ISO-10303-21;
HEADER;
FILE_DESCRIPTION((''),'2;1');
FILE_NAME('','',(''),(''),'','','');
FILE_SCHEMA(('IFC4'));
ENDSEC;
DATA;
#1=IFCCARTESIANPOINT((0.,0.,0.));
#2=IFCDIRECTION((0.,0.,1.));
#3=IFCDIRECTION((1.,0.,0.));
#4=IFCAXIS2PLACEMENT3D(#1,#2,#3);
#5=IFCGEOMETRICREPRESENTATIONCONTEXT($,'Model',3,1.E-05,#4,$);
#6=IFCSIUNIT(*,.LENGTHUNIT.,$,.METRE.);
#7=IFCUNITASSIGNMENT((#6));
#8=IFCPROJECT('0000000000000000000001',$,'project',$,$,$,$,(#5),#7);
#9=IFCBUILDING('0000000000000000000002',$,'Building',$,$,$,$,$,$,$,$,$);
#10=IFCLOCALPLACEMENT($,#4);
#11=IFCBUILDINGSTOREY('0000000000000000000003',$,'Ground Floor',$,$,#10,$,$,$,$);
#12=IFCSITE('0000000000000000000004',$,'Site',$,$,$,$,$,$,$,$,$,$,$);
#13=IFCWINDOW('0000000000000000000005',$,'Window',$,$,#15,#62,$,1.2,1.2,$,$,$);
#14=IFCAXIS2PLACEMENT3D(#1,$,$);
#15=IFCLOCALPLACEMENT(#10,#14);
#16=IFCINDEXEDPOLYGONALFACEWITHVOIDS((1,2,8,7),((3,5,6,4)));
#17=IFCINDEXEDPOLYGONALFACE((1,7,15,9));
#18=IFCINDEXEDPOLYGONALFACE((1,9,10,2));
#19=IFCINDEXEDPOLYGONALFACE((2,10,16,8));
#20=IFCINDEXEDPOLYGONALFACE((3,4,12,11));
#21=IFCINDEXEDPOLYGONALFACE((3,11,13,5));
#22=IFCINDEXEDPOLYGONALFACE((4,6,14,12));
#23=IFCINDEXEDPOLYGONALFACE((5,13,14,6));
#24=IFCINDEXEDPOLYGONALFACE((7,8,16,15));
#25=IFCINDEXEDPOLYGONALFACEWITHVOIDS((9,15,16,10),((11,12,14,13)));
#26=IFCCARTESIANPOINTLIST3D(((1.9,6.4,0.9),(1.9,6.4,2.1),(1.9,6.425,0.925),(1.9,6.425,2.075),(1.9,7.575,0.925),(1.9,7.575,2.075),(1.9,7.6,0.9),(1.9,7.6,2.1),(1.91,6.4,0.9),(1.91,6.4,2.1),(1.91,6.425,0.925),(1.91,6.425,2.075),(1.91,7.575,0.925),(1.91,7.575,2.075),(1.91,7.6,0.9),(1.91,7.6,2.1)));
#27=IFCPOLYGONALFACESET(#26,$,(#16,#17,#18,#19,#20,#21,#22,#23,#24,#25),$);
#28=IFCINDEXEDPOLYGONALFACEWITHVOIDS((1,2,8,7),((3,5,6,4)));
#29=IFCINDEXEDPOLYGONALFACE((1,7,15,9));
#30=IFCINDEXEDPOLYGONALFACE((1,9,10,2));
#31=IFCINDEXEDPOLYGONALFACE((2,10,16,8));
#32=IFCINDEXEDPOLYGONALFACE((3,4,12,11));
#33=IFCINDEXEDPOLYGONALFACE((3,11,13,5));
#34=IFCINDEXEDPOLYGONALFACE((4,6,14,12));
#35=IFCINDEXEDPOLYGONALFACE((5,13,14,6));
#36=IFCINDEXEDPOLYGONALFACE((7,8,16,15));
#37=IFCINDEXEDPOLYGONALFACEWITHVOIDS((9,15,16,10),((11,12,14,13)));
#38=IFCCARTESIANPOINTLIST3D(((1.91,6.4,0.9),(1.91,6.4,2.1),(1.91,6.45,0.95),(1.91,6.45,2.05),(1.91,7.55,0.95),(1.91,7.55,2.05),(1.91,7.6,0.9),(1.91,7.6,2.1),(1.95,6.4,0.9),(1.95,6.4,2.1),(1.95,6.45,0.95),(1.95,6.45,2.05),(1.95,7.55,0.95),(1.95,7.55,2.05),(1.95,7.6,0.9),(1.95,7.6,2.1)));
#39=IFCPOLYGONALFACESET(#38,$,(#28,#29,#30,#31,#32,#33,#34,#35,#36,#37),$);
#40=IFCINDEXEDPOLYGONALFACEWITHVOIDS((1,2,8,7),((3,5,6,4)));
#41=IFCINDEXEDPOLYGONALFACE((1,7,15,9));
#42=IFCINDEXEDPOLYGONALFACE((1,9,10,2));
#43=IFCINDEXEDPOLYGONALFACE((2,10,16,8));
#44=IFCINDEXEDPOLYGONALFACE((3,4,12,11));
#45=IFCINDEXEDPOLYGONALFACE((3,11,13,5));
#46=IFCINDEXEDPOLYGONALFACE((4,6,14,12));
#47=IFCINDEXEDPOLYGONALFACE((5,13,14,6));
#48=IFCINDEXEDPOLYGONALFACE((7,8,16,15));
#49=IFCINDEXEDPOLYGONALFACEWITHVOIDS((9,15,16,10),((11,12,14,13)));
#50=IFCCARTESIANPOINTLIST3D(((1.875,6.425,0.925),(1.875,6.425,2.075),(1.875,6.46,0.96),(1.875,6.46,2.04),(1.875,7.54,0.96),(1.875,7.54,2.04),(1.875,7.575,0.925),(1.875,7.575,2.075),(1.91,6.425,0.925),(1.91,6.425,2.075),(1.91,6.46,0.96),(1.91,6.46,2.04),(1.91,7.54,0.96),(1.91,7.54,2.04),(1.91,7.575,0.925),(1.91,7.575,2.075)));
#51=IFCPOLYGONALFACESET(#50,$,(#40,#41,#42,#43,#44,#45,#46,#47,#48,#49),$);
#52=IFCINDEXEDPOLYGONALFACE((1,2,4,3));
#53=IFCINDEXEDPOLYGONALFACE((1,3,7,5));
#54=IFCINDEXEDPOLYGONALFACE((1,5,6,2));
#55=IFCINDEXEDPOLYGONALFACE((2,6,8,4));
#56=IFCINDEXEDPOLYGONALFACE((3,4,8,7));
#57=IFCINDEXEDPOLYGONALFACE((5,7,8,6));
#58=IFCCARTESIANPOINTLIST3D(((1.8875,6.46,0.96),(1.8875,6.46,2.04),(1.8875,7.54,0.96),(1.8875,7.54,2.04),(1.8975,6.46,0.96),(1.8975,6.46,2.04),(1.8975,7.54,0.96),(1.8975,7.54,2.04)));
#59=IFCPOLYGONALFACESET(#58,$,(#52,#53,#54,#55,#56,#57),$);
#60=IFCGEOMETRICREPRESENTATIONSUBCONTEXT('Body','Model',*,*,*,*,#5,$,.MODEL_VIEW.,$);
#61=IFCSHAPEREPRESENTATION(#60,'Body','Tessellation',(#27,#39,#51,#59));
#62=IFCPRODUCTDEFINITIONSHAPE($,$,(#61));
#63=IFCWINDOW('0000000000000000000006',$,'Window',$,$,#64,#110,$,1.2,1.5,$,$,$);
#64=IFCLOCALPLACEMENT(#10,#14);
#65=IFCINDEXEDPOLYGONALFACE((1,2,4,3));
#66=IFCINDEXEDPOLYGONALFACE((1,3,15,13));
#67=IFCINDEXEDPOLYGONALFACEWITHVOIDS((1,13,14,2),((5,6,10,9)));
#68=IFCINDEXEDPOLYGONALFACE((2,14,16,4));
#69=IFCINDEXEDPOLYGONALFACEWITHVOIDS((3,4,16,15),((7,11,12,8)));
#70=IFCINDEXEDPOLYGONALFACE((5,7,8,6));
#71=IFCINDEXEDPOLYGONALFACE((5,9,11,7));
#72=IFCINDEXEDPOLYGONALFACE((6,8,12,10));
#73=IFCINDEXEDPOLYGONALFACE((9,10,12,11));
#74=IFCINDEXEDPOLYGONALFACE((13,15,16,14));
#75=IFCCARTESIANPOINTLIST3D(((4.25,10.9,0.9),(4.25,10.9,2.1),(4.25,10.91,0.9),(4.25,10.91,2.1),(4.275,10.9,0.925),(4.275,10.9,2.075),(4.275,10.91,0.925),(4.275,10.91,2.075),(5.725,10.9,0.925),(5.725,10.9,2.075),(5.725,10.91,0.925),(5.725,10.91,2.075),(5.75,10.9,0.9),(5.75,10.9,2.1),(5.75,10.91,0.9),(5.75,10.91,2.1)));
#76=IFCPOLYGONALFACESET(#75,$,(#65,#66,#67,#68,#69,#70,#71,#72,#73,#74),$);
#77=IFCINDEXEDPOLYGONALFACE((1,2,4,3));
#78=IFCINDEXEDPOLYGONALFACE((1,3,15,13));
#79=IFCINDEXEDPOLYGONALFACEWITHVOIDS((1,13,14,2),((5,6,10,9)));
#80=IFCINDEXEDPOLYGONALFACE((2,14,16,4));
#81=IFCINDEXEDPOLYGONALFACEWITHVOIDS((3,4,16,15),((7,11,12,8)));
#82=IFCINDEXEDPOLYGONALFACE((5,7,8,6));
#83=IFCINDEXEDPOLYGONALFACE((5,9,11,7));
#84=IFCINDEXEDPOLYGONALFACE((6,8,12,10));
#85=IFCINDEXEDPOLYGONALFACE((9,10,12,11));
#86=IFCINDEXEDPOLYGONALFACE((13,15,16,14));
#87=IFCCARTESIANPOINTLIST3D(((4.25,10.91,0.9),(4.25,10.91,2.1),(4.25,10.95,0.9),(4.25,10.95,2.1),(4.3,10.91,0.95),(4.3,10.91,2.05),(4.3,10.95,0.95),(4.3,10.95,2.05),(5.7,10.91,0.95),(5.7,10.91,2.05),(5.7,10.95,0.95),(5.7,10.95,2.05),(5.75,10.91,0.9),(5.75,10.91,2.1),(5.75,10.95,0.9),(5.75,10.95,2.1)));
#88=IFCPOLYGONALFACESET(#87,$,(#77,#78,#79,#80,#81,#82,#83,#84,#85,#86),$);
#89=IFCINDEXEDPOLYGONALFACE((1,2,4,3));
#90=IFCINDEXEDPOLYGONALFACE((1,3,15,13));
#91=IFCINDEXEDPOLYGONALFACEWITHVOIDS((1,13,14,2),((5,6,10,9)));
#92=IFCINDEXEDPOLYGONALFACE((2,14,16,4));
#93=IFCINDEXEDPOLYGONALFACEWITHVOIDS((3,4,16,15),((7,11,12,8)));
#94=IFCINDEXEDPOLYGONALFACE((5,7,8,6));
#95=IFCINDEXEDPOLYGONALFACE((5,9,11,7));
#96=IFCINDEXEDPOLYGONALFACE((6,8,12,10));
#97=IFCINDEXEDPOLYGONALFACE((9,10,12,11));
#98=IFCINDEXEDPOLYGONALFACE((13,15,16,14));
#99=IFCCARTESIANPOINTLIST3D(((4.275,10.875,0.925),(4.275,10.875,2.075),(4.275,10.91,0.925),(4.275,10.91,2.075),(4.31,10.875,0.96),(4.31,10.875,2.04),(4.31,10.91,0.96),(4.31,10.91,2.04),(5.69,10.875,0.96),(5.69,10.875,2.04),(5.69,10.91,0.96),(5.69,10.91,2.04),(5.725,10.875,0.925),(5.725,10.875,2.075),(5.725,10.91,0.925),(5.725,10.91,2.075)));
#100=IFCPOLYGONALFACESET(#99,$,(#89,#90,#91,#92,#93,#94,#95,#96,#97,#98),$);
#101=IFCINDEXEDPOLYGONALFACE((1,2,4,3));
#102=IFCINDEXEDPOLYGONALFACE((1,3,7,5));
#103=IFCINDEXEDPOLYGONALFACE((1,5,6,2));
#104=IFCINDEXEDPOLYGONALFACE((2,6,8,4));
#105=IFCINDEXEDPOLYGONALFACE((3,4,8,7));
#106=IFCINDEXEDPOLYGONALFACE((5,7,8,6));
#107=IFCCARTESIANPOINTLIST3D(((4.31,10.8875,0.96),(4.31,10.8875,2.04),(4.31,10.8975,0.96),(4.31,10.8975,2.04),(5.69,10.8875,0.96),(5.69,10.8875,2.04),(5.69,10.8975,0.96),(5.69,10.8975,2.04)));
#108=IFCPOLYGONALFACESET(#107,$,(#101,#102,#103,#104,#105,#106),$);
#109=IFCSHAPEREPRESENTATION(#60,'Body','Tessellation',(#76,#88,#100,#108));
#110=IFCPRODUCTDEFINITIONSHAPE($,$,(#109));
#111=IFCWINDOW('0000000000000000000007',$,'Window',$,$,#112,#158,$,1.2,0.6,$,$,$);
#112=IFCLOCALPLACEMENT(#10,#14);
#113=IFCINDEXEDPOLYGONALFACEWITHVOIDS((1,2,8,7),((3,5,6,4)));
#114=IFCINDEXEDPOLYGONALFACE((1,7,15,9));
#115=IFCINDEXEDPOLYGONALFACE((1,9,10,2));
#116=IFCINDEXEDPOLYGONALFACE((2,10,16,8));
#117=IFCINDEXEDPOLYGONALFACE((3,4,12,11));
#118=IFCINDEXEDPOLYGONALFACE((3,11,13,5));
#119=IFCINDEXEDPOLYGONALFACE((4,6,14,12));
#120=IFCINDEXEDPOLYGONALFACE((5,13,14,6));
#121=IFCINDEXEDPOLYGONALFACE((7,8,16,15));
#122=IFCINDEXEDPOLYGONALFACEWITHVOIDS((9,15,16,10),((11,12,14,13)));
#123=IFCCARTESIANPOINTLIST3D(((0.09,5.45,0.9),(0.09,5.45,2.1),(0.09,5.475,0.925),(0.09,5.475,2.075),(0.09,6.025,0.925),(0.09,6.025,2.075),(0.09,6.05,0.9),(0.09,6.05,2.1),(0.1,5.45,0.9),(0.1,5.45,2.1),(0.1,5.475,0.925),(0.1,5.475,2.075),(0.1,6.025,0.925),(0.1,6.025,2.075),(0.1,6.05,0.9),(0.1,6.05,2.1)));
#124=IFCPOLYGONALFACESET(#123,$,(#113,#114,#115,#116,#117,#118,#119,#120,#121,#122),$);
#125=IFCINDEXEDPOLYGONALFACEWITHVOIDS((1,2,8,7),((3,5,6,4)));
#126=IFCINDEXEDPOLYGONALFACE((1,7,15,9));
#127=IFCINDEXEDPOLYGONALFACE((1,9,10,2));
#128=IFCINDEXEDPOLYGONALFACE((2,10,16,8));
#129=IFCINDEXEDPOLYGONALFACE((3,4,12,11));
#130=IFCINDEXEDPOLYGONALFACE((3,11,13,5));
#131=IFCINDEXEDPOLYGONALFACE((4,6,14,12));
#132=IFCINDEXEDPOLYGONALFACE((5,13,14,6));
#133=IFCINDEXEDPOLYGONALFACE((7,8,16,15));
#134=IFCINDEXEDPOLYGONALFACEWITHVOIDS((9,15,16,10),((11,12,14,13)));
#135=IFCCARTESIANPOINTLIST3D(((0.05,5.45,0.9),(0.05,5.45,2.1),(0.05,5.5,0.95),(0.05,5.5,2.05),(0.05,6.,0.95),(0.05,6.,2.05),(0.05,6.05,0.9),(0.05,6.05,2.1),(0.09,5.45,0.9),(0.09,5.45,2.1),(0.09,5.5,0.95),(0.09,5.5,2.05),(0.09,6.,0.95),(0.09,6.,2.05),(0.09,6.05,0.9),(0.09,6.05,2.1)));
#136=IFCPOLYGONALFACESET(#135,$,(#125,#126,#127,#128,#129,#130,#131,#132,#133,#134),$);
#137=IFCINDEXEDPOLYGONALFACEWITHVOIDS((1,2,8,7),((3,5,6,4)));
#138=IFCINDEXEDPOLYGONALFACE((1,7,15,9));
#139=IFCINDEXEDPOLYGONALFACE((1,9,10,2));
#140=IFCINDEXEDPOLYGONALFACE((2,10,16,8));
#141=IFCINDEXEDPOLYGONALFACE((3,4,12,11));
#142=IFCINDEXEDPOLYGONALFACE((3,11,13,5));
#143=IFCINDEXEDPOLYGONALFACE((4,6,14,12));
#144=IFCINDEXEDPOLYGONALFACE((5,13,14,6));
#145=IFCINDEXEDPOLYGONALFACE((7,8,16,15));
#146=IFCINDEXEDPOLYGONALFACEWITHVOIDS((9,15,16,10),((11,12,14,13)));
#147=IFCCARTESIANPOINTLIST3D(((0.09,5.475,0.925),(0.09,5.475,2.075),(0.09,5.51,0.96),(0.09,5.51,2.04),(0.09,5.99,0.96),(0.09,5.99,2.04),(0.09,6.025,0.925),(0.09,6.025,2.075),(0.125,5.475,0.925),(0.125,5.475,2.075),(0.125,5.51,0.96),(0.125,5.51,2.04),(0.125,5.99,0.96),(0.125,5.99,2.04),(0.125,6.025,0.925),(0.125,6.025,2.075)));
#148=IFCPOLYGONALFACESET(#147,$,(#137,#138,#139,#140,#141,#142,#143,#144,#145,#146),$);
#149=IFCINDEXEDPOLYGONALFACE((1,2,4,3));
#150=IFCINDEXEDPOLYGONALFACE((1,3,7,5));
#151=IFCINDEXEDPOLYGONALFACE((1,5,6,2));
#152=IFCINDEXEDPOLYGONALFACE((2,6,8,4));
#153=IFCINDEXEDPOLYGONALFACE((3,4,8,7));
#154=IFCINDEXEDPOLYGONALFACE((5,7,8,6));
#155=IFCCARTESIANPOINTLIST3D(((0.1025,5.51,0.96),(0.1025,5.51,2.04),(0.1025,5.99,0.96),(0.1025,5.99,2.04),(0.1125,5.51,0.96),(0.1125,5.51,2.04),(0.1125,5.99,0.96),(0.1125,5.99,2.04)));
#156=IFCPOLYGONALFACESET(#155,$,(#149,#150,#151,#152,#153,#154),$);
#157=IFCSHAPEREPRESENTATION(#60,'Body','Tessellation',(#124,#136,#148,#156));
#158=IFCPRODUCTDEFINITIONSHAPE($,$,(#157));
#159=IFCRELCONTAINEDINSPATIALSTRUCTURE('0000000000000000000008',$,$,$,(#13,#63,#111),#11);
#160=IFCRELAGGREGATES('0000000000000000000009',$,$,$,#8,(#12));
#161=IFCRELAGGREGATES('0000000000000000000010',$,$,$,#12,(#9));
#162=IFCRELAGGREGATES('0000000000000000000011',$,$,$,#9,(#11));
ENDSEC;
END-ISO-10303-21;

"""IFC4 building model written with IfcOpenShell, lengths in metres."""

from ifc_helpers import new_model, si_unit, frame, origin_with_axes, place, context, subcontext, project, spatial, line, indexed_curve, outline, extrude, element, save


model = new_model("IFC4")

# Units and contexts
model_context = context("Model", 3, precision=1e-05, world=origin_with_axes())
body_context = subcontext(model_context, "Body", "Model", "MODEL_VIEW")
ifc_project = project(units=[si_unit("LENGTHUNIT", "METRE")], contexts=[model_context])

# Site, building, storey
site = spatial("IfcSite", under=ifc_project, Name="Site")
building = spatial("IfcBuilding", under=site, Name="Building")
storey_placement = place(None, origin_with_axes())
storey = spatial("IfcBuildingStorey", under=building, at=storey_placement, Name="Ground Floor")

# Windows
window_1_placement = place(storey_placement, frame((2.0, 6.4, 0.9), z_axis=(0.0, 0.0, 1.0), x_axis=(0.0, 1.0, 0.0)))
element("IfcWindow", 1, at=window_1_placement, inside=storey, Name="Window", OverallHeight=1.2, OverallWidth=1.2, context=body_context, shape_type="SweptSolid", body=[
    extrude(outline(indexed_curve([(0.0, 0.0), (1.2, 0.0), (1.2, 1.2), (0.0, 1.2)], segments=[line(1, 2, 3, 4, 1)]), holes=[indexed_curve([(0.025, 0.025), (1.175, 0.025), (1.175, 1.175), (0.025, 1.175)], segments=[line(1, 2, 3, 4, 1)])]), frame((0.0, 0.09, 0.0), z_axis=(0.0, -1.0, 0.0), x_axis=(1.0, 0.0, 0.0)), (0.0, 0.0, -1.0), 0.01),
    extrude(outline(indexed_curve([(0.0, 0.0), (1.2, 0.0), (1.2, 1.2), (0.0, 1.2)], segments=[line(1, 2, 3, 4, 1)]), holes=[indexed_curve([(0.05, 0.05), (1.15, 0.05), (1.15, 1.15), (0.05, 1.15)], segments=[line(1, 2, 3, 4, 1)])]), frame((0.0, 0.05, 0.0), z_axis=(0.0, -1.0, 0.0), x_axis=(1.0, 0.0, 0.0)), (0.0, 0.0, -1.0), 0.04),
    extrude(outline(indexed_curve([(0.0, 0.0), (1.15, 0.0), (1.15, 1.15), (0.0, 1.15)], segments=[line(1, 2, 3, 4, 1)]), holes=[indexed_curve([(0.035, 0.035), (1.115, 0.035), (1.115, 1.115), (0.035, 1.115)], segments=[line(1, 2, 3, 4, 1)])]), frame((0.025, 0.09, 0.025), z_axis=(0.0, -1.0, 0.0), x_axis=(1.0, 0.0, 0.0)), (0.0, 0.0, -1.0), 0.035),
    extrude(outline(indexed_curve([(0.035, 0.035), (1.115, 0.035), (1.115, 1.115), (0.035, 1.115)], segments=[line(1, 2, 3, 4, 1)])), frame((0.025, 0.1025, 0.025), z_axis=(0.0, -1.0, 0.0), x_axis=(1.0, 0.0, 0.0)), (0.0, 0.0, -1.0), 0.01),
])
window_2_placement = place(storey_placement, frame((5.75, 11.0, 0.9), z_axis=(0.0, 0.0, 1.0), x_axis=(-1.0, 0.0, 0.0)))
element("IfcWindow", 2, at=window_2_placement, inside=storey, Name="Window", OverallHeight=1.2, OverallWidth=1.5, context=body_context, shape_type="SweptSolid", body=[
    extrude(outline(indexed_curve([(0.0, 0.0), (1.5, 0.0), (1.5, 1.2), (0.0, 1.2)], segments=[line(1, 2, 3, 4, 1)]), holes=[indexed_curve([(0.025, 0.025), (1.475, 0.025), (1.475, 1.175), (0.025, 1.175)], segments=[line(1, 2, 3, 4, 1)])]), frame((0.0, 0.09, 0.0), z_axis=(0.0, -1.0, 0.0), x_axis=(1.0, 0.0, 0.0)), (0.0, 0.0, -1.0), 0.01),
    extrude(outline(indexed_curve([(0.0, 0.0), (1.5, 0.0), (1.5, 1.2), (0.0, 1.2)], segments=[line(1, 2, 3, 4, 1)]), holes=[indexed_curve([(0.05, 0.05), (1.45, 0.05), (1.45, 1.15), (0.05, 1.15)], segments=[line(1, 2, 3, 4, 1)])]), frame((0.0, 0.05, 0.0), z_axis=(0.0, -1.0, 0.0), x_axis=(1.0, 0.0, 0.0)), (0.0, 0.0, -1.0), 0.04),
    extrude(outline(indexed_curve([(0.0, 0.0), (1.45, 0.0), (1.45, 1.15), (0.0, 1.15)], segments=[line(1, 2, 3, 4, 1)]), holes=[indexed_curve([(0.035, 0.035), (1.415, 0.035), (1.415, 1.115), (0.035, 1.115)], segments=[line(1, 2, 3, 4, 1)])]), frame((0.025, 0.09, 0.025), z_axis=(0.0, -1.0, 0.0), x_axis=(1.0, 0.0, 0.0)), (0.0, 0.0, -1.0), 0.035),
    extrude(outline(indexed_curve([(0.035, 0.035), (1.415, 0.035), (1.415, 1.115), (0.035, 1.115)], segments=[line(1, 2, 3, 4, 1)])), frame((0.025, 0.1025, 0.025), z_axis=(0.0, -1.0, 0.0), x_axis=(1.0, 0.0, 0.0)), (0.0, 0.0, -1.0), 0.01),
])
window_3_placement = place(storey_placement, frame((0.0, 6.05, 0.9), z_axis=(0.0, 0.0, 1.0), x_axis=(0.0, -1.0, 0.0)))
element("IfcWindow", 3, at=window_3_placement, inside=storey, Name="Window", OverallHeight=1.2, OverallWidth=0.6, context=body_context, shape_type="SweptSolid", body=[
    extrude(outline(indexed_curve([(0.0, 0.0), (0.6, 0.0), (0.6, 1.2), (0.0, 1.2)], segments=[line(1, 2, 3, 4, 1)]), holes=[indexed_curve([(0.025, 0.025), (0.575, 0.025), (0.575, 1.175), (0.025, 1.175)], segments=[line(1, 2, 3, 4, 1)])]), frame((0.0, 0.09, 0.0), z_axis=(0.0, -1.0, 0.0), x_axis=(1.0, 0.0, 0.0)), (0.0, 0.0, -1.0), 0.01),
    extrude(outline(indexed_curve([(0.0, 0.0), (0.6, 0.0), (0.6, 1.2), (0.0, 1.2)], segments=[line(1, 2, 3, 4, 1)]), holes=[indexed_curve([(0.05, 0.05), (0.55, 0.05), (0.55, 1.15), (0.05, 1.15)], segments=[line(1, 2, 3, 4, 1)])]), frame((0.0, 0.05, 0.0), z_axis=(0.0, -1.0, 0.0), x_axis=(1.0, 0.0, 0.0)), (0.0, 0.0, -1.0), 0.04),
    extrude(outline(indexed_curve([(0.0, 0.0), (0.55, 0.0), (0.55, 1.15), (0.0, 1.15)], segments=[line(1, 2, 3, 4, 1)]), holes=[indexed_curve([(0.035, 0.035), (0.515, 0.035), (0.515, 1.115), (0.035, 1.115)], segments=[line(1, 2, 3, 4, 1)])]), frame((0.025, 0.09, 0.025), z_axis=(0.0, -1.0, 0.0), x_axis=(1.0, 0.0, 0.0)), (0.0, 0.0, -1.0), 0.035),
    extrude(outline(indexed_curve([(0.035, 0.035), (0.515, 0.035), (0.515, 1.115), (0.035, 1.115)], segments=[line(1, 2, 3, 4, 1)])), frame((0.025, 0.1025, 0.025), z_axis=(0.0, -1.0, 0.0), x_axis=(1.0, 0.0, 0.0)), (0.0, 0.0, -1.0), 0.01),
])

save(model, "model.ifc")
